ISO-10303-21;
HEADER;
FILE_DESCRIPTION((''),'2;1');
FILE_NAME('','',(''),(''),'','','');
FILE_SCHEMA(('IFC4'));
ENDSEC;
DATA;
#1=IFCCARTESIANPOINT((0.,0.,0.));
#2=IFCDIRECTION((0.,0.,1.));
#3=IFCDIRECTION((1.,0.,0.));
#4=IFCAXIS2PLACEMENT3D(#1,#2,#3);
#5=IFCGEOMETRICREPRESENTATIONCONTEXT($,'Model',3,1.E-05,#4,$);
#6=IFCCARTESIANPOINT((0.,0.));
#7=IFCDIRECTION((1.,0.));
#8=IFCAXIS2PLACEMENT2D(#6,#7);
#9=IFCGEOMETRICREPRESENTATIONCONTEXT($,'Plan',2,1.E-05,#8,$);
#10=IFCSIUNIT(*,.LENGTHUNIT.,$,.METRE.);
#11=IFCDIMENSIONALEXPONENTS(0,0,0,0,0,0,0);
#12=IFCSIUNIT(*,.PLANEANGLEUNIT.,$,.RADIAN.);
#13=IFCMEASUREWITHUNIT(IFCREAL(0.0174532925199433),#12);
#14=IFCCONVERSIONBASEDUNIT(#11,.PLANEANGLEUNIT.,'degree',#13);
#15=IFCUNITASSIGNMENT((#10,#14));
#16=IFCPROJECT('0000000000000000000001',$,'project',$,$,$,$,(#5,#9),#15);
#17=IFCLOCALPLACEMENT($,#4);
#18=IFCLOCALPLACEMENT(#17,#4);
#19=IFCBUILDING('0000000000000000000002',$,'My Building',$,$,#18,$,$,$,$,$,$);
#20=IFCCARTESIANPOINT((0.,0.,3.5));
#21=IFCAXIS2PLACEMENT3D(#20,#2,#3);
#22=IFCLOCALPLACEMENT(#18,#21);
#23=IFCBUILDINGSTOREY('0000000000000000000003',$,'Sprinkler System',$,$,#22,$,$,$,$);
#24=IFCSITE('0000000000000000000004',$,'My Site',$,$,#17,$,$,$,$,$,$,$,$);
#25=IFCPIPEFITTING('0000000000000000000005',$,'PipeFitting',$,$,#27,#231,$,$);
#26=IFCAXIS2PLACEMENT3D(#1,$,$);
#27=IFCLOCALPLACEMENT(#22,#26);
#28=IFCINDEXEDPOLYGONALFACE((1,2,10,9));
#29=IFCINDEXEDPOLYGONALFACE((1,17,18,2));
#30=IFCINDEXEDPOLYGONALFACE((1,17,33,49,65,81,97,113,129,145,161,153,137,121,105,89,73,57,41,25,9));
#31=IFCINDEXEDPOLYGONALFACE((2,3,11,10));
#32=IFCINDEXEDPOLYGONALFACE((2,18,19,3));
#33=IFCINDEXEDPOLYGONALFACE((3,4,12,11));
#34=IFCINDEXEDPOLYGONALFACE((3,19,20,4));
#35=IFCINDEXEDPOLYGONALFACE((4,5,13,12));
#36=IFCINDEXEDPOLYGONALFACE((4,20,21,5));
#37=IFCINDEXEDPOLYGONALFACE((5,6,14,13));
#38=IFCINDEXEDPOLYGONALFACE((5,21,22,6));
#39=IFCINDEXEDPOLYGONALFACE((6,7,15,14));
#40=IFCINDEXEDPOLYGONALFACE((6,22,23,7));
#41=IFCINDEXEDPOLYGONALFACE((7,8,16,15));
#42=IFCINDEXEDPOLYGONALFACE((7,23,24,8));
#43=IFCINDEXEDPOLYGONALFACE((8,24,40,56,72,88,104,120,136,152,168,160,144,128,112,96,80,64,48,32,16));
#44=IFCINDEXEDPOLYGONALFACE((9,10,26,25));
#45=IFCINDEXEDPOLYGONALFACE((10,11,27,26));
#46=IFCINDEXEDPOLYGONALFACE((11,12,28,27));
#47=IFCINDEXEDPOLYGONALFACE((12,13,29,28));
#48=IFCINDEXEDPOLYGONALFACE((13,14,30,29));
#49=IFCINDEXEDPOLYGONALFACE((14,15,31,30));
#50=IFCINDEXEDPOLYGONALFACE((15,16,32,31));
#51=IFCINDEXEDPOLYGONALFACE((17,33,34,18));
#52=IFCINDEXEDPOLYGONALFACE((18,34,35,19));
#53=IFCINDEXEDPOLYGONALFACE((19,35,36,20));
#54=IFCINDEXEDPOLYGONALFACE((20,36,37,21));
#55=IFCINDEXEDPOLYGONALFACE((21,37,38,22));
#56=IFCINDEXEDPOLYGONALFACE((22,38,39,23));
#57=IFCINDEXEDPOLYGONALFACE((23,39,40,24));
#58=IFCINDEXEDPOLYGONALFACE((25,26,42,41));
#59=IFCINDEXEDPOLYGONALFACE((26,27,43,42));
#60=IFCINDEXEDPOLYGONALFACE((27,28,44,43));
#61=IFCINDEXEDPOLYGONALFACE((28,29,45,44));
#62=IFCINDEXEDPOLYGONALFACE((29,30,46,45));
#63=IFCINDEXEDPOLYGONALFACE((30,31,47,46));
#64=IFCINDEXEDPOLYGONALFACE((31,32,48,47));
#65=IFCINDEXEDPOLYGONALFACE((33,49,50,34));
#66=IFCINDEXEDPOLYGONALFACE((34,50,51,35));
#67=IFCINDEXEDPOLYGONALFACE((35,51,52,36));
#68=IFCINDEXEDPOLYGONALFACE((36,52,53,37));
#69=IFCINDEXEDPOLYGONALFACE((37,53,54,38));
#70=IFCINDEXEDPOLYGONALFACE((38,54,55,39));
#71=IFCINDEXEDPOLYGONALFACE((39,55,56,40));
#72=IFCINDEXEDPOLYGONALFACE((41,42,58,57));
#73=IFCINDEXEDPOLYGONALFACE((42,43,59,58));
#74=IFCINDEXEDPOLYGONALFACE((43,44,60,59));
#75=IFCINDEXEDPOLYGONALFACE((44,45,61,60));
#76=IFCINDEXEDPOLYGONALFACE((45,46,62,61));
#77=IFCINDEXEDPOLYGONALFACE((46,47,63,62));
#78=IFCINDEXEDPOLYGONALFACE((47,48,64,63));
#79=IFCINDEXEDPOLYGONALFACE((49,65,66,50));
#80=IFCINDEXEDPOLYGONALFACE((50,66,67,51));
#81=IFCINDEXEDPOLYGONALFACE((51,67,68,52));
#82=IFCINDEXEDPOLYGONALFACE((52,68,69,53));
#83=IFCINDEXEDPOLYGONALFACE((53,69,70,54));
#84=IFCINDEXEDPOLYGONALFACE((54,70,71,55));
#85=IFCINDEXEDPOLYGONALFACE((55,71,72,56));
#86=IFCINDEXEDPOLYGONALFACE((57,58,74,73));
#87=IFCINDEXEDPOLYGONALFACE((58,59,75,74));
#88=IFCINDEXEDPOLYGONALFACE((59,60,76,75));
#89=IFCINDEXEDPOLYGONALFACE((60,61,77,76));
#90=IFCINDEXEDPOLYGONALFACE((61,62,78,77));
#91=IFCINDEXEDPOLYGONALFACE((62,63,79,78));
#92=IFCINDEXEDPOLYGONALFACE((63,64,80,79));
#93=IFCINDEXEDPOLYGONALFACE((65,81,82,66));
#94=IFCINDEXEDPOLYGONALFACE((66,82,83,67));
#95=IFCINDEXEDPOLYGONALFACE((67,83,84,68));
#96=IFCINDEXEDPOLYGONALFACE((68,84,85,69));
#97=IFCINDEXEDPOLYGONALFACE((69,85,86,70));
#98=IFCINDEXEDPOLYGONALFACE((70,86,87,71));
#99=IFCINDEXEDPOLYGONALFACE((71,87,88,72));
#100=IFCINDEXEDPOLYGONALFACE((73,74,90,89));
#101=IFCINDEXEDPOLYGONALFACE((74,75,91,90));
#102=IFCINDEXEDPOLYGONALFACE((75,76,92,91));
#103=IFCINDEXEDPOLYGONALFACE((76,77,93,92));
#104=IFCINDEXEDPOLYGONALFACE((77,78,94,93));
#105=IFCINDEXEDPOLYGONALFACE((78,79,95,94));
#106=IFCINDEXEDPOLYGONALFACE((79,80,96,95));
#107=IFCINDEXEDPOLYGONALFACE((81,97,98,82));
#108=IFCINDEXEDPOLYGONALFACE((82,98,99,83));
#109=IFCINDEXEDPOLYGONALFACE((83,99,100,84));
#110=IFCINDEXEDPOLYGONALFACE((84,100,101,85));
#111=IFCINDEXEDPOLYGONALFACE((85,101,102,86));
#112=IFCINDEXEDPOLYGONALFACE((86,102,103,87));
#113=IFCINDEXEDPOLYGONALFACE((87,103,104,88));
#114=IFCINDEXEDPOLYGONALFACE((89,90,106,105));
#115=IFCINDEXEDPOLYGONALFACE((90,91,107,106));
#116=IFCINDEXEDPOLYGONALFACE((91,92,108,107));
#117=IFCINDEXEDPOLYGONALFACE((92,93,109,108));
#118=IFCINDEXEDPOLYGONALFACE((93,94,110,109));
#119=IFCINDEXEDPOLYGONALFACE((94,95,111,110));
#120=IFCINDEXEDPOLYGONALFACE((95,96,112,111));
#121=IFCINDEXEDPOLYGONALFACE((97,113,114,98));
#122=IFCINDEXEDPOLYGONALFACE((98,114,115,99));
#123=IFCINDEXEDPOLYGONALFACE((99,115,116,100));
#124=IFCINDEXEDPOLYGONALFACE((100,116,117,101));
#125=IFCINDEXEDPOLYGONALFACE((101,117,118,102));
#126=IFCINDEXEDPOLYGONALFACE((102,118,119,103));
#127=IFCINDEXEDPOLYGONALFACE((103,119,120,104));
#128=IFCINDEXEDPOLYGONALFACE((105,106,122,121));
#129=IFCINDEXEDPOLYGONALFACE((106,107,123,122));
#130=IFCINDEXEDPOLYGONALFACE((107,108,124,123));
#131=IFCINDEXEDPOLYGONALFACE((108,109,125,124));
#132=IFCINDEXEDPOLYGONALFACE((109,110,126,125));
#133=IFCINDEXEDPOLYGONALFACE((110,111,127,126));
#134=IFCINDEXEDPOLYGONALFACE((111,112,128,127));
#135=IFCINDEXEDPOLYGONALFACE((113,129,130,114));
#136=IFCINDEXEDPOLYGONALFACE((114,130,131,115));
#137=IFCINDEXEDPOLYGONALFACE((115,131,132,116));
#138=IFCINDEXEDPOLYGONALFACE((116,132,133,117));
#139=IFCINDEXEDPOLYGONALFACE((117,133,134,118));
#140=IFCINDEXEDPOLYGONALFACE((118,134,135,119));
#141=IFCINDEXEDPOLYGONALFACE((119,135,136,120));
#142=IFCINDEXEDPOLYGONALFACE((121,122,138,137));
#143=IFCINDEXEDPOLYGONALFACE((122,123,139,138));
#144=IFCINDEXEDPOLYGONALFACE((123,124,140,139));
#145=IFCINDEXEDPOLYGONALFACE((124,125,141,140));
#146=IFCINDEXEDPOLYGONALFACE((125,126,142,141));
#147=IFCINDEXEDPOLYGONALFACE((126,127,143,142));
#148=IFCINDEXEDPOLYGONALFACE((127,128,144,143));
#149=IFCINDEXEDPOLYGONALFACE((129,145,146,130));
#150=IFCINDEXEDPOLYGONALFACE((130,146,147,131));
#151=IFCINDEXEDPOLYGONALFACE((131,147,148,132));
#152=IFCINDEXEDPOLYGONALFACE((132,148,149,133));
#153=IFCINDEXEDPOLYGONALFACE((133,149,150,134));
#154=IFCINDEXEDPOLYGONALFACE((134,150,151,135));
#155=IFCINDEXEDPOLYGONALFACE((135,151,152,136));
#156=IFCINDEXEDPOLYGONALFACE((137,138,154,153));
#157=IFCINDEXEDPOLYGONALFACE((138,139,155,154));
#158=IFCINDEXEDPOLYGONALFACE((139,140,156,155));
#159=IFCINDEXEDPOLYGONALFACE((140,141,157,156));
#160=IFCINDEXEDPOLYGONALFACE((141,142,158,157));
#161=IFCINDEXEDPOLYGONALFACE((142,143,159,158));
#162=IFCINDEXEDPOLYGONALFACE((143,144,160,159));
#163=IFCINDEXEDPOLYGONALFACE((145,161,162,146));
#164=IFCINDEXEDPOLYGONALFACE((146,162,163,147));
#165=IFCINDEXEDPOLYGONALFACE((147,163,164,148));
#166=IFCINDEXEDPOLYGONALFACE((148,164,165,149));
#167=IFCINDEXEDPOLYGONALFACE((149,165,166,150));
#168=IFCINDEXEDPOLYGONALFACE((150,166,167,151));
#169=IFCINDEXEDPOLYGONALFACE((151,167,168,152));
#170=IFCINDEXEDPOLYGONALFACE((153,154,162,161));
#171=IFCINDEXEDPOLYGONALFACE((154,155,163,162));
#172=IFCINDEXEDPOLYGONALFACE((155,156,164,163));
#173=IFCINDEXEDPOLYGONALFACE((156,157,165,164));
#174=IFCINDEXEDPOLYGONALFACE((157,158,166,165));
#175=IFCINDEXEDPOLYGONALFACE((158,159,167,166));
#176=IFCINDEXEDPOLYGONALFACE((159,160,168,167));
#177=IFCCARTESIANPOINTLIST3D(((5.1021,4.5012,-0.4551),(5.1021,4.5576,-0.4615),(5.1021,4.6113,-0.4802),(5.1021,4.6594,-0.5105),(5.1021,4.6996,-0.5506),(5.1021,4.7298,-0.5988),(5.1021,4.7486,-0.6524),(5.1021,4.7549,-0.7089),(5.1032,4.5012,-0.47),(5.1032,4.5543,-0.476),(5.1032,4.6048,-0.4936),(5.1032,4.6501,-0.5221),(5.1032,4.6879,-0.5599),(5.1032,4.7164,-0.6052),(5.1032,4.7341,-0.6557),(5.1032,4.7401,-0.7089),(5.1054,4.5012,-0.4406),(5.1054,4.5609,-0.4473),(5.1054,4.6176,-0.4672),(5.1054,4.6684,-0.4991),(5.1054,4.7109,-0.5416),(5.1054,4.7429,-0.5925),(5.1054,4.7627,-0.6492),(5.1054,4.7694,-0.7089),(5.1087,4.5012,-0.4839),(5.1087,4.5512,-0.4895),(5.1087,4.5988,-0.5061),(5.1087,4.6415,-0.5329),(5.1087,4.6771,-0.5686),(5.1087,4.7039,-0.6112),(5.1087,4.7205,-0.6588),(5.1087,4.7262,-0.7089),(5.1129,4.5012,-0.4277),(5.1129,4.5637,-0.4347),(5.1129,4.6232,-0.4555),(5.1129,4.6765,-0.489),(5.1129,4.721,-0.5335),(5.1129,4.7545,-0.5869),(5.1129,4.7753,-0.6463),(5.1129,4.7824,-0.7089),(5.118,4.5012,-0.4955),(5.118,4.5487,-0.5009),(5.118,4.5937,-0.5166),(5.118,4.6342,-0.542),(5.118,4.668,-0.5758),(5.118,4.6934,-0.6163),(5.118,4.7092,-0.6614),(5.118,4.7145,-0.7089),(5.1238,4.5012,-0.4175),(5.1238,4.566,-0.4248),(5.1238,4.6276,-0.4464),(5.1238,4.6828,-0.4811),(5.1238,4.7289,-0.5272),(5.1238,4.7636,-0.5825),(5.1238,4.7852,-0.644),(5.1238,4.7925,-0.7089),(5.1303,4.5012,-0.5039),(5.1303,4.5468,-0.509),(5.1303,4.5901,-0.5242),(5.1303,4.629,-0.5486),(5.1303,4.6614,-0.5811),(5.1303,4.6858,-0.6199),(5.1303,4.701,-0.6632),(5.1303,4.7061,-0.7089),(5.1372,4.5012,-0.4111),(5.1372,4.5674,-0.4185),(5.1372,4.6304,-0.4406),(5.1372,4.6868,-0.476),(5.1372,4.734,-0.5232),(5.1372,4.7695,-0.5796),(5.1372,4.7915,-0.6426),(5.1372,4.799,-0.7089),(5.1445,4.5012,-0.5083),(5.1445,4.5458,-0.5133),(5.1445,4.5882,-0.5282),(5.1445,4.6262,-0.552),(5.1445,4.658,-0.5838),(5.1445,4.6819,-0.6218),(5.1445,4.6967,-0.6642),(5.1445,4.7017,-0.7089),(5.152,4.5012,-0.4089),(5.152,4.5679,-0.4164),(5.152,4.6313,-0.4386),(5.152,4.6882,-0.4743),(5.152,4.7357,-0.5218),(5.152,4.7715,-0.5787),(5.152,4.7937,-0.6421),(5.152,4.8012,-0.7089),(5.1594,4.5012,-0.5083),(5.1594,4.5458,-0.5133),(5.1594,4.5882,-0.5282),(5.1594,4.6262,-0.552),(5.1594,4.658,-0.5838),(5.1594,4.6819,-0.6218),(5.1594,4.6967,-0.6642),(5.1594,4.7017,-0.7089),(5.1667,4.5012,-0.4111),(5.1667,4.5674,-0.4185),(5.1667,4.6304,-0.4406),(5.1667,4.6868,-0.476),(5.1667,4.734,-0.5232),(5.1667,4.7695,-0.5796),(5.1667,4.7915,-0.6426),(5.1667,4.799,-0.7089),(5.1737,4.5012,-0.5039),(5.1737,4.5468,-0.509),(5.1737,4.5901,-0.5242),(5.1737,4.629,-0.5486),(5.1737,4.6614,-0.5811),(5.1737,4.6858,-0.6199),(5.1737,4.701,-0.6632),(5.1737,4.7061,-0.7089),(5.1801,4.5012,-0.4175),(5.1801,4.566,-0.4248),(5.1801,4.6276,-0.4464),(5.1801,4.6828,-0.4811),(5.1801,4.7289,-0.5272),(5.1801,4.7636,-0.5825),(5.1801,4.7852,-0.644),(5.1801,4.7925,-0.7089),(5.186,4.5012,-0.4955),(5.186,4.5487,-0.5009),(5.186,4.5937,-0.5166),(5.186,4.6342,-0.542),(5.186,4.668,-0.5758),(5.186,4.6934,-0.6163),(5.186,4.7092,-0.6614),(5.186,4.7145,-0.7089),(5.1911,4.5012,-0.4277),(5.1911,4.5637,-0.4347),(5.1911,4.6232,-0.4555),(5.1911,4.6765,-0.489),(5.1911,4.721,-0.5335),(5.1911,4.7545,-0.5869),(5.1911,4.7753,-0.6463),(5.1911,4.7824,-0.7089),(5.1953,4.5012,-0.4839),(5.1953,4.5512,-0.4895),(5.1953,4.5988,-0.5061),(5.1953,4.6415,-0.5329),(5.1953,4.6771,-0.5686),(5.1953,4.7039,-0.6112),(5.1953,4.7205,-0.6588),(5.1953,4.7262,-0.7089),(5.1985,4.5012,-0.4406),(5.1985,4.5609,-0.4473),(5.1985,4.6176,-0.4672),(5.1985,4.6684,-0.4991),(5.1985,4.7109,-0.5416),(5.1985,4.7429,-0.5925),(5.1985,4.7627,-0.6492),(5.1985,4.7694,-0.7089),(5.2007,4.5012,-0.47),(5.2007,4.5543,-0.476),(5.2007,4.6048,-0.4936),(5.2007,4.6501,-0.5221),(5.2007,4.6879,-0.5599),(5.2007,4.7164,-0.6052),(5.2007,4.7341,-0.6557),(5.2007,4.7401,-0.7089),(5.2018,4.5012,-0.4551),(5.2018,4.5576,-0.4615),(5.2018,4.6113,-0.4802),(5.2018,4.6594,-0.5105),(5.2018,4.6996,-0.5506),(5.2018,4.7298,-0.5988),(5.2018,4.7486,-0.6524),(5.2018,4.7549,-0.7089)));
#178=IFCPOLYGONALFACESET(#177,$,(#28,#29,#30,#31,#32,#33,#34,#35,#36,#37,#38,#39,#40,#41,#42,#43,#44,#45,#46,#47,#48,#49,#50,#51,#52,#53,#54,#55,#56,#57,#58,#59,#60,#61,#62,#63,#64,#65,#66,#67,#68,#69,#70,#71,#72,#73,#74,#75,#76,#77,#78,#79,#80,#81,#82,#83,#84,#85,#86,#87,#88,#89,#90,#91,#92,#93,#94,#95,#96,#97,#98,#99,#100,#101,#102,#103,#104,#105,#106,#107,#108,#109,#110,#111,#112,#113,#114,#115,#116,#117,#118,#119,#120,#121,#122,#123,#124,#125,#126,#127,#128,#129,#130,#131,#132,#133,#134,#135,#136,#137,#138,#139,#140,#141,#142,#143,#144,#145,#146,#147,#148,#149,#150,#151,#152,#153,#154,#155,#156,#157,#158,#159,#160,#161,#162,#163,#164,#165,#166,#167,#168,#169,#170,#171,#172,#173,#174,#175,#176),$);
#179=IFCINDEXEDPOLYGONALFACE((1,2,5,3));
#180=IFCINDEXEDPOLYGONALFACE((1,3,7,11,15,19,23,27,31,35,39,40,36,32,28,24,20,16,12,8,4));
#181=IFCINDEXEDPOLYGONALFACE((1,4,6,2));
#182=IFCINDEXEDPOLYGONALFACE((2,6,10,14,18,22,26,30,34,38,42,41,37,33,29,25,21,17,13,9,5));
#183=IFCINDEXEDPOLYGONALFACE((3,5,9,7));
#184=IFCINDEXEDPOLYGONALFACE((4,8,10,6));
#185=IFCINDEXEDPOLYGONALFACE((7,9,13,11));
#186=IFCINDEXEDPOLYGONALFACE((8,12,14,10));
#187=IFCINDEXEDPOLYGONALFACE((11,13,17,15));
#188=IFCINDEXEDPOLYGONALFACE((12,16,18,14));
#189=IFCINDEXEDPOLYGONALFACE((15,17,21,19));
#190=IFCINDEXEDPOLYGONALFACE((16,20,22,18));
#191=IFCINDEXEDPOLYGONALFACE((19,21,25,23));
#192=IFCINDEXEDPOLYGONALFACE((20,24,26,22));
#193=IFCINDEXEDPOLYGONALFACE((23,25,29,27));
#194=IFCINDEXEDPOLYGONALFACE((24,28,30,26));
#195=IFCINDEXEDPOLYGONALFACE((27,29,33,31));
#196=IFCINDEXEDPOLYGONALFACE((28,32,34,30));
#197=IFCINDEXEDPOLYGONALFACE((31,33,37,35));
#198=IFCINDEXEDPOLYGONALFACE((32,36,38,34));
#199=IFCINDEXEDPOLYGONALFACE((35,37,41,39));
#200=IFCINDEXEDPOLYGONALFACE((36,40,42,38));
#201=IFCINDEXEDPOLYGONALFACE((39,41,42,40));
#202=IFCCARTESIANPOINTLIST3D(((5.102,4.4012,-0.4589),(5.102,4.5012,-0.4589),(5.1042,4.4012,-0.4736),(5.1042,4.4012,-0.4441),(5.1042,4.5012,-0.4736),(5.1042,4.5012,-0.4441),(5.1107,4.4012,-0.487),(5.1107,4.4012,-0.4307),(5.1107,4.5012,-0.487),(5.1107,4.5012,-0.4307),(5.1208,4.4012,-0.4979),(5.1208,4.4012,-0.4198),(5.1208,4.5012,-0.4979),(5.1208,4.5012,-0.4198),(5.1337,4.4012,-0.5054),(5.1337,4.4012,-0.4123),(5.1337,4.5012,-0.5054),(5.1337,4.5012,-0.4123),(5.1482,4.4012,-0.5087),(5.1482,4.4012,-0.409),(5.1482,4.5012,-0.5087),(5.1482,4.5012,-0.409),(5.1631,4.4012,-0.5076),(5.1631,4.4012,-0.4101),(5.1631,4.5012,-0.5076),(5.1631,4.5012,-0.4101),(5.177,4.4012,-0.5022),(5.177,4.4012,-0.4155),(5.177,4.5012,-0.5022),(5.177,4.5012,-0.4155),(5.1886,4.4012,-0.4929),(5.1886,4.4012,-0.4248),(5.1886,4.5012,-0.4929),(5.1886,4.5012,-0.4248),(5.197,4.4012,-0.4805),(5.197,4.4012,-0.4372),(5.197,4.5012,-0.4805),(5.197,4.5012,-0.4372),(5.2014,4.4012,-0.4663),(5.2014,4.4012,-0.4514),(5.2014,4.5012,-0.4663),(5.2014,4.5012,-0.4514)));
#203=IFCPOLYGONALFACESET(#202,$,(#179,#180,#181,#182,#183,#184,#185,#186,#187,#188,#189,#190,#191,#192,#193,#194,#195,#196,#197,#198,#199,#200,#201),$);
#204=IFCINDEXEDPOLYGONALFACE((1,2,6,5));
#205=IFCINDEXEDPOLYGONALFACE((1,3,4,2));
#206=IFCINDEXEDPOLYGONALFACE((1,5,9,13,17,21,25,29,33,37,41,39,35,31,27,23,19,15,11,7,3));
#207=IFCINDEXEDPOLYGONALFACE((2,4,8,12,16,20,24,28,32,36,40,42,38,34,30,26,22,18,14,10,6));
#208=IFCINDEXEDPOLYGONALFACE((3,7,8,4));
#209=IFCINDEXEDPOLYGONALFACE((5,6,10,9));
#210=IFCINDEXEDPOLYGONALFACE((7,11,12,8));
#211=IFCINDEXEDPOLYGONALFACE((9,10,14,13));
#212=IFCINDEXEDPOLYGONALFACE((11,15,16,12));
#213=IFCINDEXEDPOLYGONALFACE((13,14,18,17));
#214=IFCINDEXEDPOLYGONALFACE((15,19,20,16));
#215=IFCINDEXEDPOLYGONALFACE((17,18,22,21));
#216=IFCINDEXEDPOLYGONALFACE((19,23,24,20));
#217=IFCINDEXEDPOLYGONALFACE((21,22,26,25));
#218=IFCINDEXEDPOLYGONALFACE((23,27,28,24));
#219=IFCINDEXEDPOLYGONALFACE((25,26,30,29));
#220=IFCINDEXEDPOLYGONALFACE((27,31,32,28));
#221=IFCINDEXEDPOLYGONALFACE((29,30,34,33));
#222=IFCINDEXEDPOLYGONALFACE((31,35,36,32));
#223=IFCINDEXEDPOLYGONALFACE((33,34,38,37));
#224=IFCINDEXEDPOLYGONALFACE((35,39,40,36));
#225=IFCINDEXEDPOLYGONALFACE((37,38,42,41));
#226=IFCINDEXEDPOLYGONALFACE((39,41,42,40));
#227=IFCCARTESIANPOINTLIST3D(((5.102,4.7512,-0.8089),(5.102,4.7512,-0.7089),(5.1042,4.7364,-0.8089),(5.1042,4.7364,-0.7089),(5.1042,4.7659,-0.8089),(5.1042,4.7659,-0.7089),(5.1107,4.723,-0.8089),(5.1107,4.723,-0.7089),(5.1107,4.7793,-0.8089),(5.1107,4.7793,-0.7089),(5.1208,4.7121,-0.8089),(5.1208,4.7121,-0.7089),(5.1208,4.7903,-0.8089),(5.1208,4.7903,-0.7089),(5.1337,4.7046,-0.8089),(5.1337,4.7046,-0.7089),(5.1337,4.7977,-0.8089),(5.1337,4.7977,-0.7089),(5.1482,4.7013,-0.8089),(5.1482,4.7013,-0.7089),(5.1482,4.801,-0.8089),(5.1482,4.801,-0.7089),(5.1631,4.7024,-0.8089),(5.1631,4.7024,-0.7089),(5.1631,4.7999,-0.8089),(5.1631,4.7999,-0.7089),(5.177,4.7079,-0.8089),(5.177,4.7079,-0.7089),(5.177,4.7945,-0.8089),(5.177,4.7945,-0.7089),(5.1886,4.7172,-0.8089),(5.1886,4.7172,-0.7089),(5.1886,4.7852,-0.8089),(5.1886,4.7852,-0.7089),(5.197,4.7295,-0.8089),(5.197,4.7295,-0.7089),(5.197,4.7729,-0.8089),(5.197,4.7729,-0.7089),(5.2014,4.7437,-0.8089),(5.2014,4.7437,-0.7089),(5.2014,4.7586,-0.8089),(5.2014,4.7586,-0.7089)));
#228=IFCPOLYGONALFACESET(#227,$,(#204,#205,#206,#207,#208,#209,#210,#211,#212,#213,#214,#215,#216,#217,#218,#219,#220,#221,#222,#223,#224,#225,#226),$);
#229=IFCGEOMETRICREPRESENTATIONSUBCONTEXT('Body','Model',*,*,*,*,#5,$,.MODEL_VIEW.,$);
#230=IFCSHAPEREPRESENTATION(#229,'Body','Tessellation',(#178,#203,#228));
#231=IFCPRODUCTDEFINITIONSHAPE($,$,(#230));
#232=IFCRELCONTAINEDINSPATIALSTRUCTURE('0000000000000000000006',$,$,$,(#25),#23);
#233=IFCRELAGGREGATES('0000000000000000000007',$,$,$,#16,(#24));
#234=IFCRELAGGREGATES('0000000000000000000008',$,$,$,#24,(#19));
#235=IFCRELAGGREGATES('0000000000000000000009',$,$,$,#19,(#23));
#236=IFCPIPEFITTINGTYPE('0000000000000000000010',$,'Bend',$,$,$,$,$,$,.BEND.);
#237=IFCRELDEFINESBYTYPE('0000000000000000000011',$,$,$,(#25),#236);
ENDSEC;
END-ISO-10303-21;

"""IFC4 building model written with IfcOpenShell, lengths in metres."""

from ifc_helpers import new_model, entity, si_unit, converted_unit, frame, origin_with_axes, origin_2d_with_axis, place, context, subcontext, project, spatial, circle, extrude, source, transform, mapped, type_object, type_shapes, element, save


model = new_model("IFC4")

# Units and contexts
model_context = context("Model", 3, precision=1e-05, world=origin_with_axes())
plan_context = context("Plan", 2, precision=1e-05, world=origin_2d_with_axis())
body_context = subcontext(model_context, "Body", "Model", "MODEL_VIEW")
ifc_project = project(units=[si_unit("LENGTHUNIT", "METRE"), converted_unit("PLANEANGLEUNIT", "degree", entity("IfcReal", 0.0174532925199433), si_unit("PLANEANGLEUNIT", "RADIAN"), dimensions=[0, 0, 0, 0, 0, 0, 0])], contexts=[model_context, plan_context])

# Site, building, storey
site_placement = place(None, origin_with_axes())
site = spatial("IfcSite", under=ifc_project, at=site_placement, Name="My Site")
building_placement = place(site_placement, origin_with_axes())
building = spatial("IfcBuilding", under=site, at=building_placement, Name="My Building")
storey_placement = place(building_placement, frame((0.0, 0.0, 3.5), z_axis=(0.0, 0.0, 1.0), x_axis=(1.0, 0.0, 0.0)))
storey = spatial("IfcBuildingStorey", under=building, at=storey_placement, Name="Sprinkler System")

# Pipe fitting
pipe_fitting_type_1 = type_object("IfcPipeFittingType", Name="Bend", PredefinedType="BEND")
shared_shape_1 = source(origin_with_axes(), body_context, "Body", "SolidModel", [
    entity("IfcSweptDiskSolid", entity("IfcIndexedPolyCurve", entity("IfcCartesianPointList3D", [[0.0, 0.0, 0.1], [0.0, -0.0732, 0.2768], [0.0, -0.25, 0.35]]), [entity("IfcArcIndex", [1, 2, 3])]), 0.05),
    extrude(circle(Radius=0.05), origin_with_axes(), (0.0, 0.0, 1.0), 0.1),
    extrude(circle(Radius=0.05), frame((0.0, -0.25, 0.35), z_axis=(0.0, -1.0, 0.0), x_axis=(1.0, 0.0, 0.0)), (0.0, 0.0, 1.0), 0.1),
])
type_shapes(pipe_fitting_type_1, [shared_shape_1])
for number, where, z_axis, x_axis, name in (
    (1, (5.152, 4.4012, -0.4589), (0.0, 1.0, 0.0), (-1.0, 0.0, 0.0), "PipeFitting"),
):
    element("IfcPipeFitting", number, at=place(storey_placement, frame(where, z_axis=z_axis, x_axis=x_axis)), inside=storey, type_object=pipe_fitting_type_1, Name=name, context=body_context, shape_type="MappedRepresentation", body=[
        mapped(shared_shape_1, transform((0.0, 0.0, 0.0), x_axis=(1.0, 0.0, 0.0), y_axis=(0.0, 1.0, 0.0), z_axis=(0.0, 0.0, 1.0), scale=1.0)),
    ])

save(model, "model.ifc")
